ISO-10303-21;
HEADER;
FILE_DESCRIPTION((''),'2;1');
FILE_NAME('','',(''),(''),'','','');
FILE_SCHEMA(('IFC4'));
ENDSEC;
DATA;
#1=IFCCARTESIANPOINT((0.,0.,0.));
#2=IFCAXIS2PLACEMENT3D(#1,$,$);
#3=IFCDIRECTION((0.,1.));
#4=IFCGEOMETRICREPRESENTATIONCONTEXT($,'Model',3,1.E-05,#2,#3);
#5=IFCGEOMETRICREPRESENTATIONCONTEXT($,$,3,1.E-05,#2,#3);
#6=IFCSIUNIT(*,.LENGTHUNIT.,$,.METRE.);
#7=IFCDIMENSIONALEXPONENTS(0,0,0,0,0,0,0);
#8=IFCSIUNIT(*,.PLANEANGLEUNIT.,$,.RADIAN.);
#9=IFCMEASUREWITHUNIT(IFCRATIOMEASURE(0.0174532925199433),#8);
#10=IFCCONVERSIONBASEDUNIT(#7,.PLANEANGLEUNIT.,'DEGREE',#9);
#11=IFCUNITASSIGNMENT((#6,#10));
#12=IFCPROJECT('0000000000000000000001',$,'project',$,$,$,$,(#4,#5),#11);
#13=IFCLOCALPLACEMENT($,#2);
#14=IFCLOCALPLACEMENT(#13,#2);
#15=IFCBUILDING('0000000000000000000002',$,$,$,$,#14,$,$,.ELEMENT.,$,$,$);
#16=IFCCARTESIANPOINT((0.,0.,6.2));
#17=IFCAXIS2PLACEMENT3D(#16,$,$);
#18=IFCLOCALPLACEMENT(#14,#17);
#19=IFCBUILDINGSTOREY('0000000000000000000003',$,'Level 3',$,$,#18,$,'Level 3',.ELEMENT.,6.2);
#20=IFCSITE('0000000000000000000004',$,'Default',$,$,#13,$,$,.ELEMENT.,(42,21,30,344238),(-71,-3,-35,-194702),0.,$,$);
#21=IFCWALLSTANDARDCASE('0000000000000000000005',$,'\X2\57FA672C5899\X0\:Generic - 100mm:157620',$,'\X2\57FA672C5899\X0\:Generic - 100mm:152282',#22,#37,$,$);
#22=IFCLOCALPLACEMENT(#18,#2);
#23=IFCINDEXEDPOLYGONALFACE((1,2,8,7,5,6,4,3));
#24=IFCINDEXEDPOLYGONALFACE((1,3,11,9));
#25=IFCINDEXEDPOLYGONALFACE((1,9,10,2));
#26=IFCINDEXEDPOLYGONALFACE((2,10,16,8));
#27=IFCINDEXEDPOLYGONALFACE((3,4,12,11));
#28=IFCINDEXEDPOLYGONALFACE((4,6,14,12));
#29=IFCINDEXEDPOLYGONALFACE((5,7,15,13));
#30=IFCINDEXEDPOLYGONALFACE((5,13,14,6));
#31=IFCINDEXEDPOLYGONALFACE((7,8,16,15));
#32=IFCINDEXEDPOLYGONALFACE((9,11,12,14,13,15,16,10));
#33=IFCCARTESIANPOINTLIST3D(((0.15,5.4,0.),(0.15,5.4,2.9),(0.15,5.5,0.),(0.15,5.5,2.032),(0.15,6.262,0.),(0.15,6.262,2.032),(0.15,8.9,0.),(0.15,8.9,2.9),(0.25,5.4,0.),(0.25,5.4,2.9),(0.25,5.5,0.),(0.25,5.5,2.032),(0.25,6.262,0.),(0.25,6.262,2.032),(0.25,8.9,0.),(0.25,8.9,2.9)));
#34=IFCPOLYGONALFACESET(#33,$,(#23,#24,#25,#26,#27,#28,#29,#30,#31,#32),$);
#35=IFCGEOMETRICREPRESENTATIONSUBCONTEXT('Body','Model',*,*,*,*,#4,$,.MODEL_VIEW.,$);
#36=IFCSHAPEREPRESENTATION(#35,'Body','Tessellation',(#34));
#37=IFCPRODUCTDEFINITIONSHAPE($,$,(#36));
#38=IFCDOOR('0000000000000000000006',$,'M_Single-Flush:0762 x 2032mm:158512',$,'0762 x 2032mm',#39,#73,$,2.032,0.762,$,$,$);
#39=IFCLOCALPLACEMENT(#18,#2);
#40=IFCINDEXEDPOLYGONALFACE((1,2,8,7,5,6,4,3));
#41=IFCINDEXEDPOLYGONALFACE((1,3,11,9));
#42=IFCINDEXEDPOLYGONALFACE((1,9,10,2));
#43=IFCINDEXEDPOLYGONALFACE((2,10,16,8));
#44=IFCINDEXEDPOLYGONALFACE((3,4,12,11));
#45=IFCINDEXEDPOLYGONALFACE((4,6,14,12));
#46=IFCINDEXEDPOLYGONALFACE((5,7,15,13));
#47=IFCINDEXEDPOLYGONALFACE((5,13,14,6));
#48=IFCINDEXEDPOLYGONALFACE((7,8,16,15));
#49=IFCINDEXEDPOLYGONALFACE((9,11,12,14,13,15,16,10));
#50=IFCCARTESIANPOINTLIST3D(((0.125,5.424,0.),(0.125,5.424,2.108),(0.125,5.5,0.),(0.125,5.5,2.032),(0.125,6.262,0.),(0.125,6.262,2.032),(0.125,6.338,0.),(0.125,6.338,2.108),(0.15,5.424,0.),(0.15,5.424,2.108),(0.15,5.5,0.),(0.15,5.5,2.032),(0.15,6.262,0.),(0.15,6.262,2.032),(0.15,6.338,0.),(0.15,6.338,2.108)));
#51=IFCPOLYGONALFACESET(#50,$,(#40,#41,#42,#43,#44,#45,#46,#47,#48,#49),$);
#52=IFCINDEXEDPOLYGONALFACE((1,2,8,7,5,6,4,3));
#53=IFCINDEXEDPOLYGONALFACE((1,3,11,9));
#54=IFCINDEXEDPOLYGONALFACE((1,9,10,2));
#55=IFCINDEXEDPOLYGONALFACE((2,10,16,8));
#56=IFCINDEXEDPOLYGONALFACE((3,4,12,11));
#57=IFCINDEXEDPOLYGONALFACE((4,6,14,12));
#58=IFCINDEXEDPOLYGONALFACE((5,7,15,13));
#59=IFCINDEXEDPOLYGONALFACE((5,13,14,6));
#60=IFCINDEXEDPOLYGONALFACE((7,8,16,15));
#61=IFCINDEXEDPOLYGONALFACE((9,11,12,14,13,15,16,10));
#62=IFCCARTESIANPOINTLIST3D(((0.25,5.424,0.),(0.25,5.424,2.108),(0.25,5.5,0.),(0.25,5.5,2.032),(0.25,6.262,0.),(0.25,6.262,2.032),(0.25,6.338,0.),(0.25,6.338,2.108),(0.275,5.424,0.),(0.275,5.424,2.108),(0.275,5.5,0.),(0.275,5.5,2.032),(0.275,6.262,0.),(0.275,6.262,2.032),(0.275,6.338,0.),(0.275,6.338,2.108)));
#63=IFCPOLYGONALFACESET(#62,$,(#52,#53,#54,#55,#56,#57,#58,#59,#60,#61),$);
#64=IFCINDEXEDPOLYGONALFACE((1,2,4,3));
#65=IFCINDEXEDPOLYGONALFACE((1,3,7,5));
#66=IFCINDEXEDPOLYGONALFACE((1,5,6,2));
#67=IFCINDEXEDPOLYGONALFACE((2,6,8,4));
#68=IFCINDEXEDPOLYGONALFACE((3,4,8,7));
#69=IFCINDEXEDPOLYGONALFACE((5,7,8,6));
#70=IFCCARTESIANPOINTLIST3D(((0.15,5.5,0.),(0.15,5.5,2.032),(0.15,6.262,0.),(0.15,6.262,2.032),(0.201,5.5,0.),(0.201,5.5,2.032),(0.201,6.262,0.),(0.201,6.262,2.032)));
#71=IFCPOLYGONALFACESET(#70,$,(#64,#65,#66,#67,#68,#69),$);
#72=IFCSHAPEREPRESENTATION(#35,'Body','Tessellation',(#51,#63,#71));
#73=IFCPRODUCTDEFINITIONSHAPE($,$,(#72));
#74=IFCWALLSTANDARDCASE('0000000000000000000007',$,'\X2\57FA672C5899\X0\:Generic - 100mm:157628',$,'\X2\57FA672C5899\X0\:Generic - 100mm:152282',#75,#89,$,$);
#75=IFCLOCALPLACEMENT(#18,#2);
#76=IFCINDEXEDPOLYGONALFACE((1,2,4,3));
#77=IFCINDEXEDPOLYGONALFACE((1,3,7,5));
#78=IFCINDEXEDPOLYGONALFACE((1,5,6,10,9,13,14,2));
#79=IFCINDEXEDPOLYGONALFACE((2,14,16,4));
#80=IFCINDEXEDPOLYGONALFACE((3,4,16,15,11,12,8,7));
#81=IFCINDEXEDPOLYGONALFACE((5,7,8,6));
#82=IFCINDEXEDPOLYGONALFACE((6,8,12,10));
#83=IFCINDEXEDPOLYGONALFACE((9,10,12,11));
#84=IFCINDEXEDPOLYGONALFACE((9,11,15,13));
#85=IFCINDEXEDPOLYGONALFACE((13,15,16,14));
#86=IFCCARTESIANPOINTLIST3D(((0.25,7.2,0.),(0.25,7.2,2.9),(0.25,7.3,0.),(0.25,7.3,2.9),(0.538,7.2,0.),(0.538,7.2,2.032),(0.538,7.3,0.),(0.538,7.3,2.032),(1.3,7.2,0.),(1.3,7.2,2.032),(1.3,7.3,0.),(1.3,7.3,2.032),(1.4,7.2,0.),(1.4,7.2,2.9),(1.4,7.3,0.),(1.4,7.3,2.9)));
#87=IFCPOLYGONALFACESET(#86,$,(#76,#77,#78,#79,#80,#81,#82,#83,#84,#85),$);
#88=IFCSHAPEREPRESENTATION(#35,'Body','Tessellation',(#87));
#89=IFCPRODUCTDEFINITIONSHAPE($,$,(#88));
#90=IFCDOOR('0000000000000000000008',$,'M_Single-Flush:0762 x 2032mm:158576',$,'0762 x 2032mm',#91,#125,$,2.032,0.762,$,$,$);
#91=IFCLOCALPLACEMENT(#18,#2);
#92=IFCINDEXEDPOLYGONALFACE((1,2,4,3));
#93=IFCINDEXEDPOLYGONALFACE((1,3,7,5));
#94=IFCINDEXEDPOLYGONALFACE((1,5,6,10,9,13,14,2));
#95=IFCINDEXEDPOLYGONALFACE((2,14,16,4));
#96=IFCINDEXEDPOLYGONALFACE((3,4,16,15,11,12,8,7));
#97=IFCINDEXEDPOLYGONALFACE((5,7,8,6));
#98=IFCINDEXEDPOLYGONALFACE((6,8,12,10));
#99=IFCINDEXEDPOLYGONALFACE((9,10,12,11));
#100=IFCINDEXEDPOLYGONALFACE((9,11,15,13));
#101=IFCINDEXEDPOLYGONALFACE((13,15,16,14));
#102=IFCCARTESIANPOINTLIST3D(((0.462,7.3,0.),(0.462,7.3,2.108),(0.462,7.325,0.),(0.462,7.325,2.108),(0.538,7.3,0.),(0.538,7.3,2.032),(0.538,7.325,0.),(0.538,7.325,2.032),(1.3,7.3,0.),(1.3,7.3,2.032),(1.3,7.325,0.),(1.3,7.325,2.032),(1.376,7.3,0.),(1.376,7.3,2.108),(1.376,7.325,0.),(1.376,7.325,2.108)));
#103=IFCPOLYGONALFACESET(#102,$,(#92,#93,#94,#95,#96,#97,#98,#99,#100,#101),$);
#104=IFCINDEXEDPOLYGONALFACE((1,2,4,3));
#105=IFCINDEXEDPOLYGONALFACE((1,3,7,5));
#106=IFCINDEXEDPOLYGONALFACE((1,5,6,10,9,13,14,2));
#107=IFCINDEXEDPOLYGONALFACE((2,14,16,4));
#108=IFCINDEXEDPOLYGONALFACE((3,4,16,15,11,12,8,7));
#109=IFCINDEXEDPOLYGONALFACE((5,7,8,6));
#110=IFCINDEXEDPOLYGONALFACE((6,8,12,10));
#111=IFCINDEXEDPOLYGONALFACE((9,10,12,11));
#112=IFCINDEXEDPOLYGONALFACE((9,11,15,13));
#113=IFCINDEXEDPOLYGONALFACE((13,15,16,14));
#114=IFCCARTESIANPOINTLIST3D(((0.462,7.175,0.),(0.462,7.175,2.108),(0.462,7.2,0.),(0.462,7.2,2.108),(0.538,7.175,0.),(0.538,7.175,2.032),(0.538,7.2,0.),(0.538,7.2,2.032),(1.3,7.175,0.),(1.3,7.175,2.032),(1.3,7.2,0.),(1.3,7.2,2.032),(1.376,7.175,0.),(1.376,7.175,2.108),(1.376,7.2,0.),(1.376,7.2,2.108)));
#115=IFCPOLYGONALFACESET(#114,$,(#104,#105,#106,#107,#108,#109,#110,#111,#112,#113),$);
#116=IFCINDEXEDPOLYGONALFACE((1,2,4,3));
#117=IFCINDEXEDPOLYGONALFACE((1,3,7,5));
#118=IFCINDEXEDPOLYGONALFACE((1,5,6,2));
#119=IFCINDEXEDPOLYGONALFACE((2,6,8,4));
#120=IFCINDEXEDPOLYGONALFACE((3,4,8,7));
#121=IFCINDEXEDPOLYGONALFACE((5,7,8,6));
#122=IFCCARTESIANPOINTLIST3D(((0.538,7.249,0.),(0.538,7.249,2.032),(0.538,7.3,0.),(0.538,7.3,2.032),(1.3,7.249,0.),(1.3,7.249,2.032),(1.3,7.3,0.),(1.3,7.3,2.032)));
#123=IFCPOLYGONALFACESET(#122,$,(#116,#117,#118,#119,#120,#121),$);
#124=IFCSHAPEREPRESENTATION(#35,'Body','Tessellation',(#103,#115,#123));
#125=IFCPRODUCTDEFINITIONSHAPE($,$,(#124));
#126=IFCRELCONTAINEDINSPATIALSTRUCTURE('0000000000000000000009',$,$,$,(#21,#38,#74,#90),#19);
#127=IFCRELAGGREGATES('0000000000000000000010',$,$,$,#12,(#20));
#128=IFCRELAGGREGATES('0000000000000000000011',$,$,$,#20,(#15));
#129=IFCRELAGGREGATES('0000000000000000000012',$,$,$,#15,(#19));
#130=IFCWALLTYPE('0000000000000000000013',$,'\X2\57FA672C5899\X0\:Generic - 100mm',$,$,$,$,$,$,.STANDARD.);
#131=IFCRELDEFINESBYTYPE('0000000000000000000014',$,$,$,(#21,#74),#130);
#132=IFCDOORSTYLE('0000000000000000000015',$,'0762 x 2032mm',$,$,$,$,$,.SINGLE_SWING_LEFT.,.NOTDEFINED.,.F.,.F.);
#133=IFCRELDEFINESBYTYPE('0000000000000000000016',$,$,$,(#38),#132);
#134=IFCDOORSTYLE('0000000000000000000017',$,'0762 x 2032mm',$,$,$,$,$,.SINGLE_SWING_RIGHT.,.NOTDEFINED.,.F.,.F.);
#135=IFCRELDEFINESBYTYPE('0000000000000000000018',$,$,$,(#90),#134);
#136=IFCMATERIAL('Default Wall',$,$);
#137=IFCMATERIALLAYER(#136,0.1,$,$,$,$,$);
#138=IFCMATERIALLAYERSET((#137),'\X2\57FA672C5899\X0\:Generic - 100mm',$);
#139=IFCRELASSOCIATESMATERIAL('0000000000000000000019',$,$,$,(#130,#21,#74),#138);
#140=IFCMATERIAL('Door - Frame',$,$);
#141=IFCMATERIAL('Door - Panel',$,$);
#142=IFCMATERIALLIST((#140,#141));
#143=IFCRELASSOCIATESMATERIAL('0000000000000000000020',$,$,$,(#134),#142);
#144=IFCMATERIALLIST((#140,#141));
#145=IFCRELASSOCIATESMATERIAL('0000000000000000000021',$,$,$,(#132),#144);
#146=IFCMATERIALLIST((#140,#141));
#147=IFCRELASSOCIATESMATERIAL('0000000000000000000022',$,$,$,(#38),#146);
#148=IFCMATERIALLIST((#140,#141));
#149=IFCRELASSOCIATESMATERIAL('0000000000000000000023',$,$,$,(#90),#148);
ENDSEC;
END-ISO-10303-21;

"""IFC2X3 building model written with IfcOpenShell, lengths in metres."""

from ifc_helpers import new_model, entity, si_unit, converted_unit, direction, frame, frame_2d, origin, origin_2d_with_axis, place, context, subcontext, project, spatial, polyline, rectangle, outline, extrude, clip, bounded_halfspace, source, transform, mapped, material, material_list, layer, layer_set, layer_usage, type_object, type_shapes, element, fill, save


model = new_model("IFC2X3")

# Units and contexts
model_context = context("Model", 3, precision=1e-05, world=origin(), true_north=direction((0.0, 1.0)))
context_of_model = context(None, 3, precision=1e-05, world=origin(), true_north=direction((0.0, 1.0)))
body_context = subcontext(model_context, "Body", "Model", "MODEL_VIEW")
ifc_project = project(units=[si_unit("LENGTHUNIT", "METRE"), converted_unit("PLANEANGLEUNIT", "DEGREE", entity("IfcRatioMeasure", 0.0174532925199433), si_unit("PLANEANGLEUNIT", "RADIAN"), dimensions=[0, 0, 0, 0, 0, 0, 0])], contexts=[model_context, context_of_model])

# Site, building, storey
site_placement = place(None, origin())
site = spatial("IfcSite", under=ifc_project, at=site_placement, Name="Default", CompositionType="ELEMENT", RefLatitude=(42, 21, 30, 344238), RefLongitude=(-71, -3, -35, -194702), RefElevation=0.0)
building_placement = place(site_placement, origin())
building = spatial("IfcBuilding", under=site, at=building_placement, CompositionType="ELEMENT")
storey_placement = place(building_placement, frame((0.0, 0.0, 6.2)))
storey = spatial("IfcBuildingStorey", under=building, at=storey_placement, Name="Level 3", LongName="Level 3", CompositionType="ELEMENT", Elevation=6.2)

# Shared definitions
ifc_material_1 = material(Name="Default Wall")

# Shared definitions
ifc_material_2 = material(Name="Door - Panel")
ifc_material_3 = material(Name="Door - Frame")

# Shared definitions
ifc_layer_1 = layer(ifc_material_1, 0.1)
ifc_layer_set_1 = layer_set([ifc_layer_1], Name="基本墙:Generic - 100mm")
wall_type_1 = type_object("IfcWallType", Name="基本墙:Generic - 100mm", PredefinedType="STANDARD", material=ifc_layer_set_1)

# Shared definitions
ifc_material_list_1 = material_list([ifc_material_3, ifc_material_2])
door_style_1 = type_object("IfcDoorStyle", Name="0762 x 2032mm", ConstructionType="NOTDEFINED", OperationType="SINGLE_SWING_RIGHT", ParameterTakesPrecedence=False, Sizeable=False, material=ifc_material_list_1)
shared_shape_1 = source(origin(), body_context, "Body", "SweptSolid", [
    extrude(outline(polyline([(-0.457, -1.073), (0.457, -1.073), (0.457, 1.035), (0.381, 1.035), (0.381, -0.997), (-0.381, -0.997), (-0.381, 1.035), (-0.457, 1.035), (-0.457, -1.073)])), frame((0.381, 0.1, 1.035), z_axis=(0.0, 1.0, 0.0), x_axis=(1.0, 0.0, 0.0)), (0.0, 0.0, 1.0), 0.025),
    extrude(outline(polyline([(-1.073, -0.457), (1.035, -0.457), (1.035, -0.381), (-0.997, -0.381), (-0.997, 0.381), (1.035, 0.381), (1.035, 0.457), (-1.073, 0.457), (-1.073, -0.457)])), frame((0.381, -0.025, 1.035), z_axis=(0.0, 1.0, 0.0), x_axis=(0.0, 0.0, -1.0)), (0.0, 0.0, 1.0), 0.025),
    extrude(rectangle(XDim=0.051, YDim=0.762, at=origin_2d_with_axis()), frame((0.381, 0.0745, 0.0), z_axis=(0.0, 0.0, 1.0), x_axis=(0.0, 1.0, 0.0)), (0.0, 0.0, 1.0), 2.032),
])
type_shapes(door_style_1, [shared_shape_1])

# Walls, openings, doors
ifc_layer_usage_1 = layer_usage(ifc_layer_set_1, "AXIS2", "NEGATIVE", 0.05)
wall_1_placement = place(storey_placement, frame((0.2, 8.9, 0.0), z_axis=(0.0, 0.0, 1.0), x_axis=(0.0, -1.0, 0.0)))
wall_1 = element("IfcWallStandardCase", 1, at=wall_1_placement, inside=storey, type_object=wall_type_1, material=ifc_layer_usage_1, Name="基本墙:Generic - 100mm:157620", ObjectType="基本墙:Generic - 100mm:152282", context=body_context, shape_type="Clipping", body=[
    clip(extrude(rectangle(XDim=3.5, YDim=0.1, at=frame_2d((1.75, 0.0), x_axis=(-1.0, 0.0))), origin(), (0.0, 0.0, 1.0), 3.2), bounded_halfspace(frame((0.0, -0.05, 2.9), z_axis=(0.0, 0.0, -1.0), x_axis=(1.0, 0.0, 0.0)), True, frame((0.0, -0.05, 2.9), z_axis=(0.0, 0.0, -1.0), x_axis=(1.0, 0.0, 0.0)), polyline([(0.0, 0.0), (0.0, -0.1), (1.6, -0.1), (1.7, -0.1), (3.5, -0.1), (3.5, 0.0), (0.0, 0.0)]))),
])
opening_1_placement = place(wall_1_placement, frame((3.4, 0.05, 0.0)))
opening_1 = element("IfcOpeningElement", 2, at=opening_1_placement, cuts=wall_1, ObjectType="Opening", context=body_context, shape_type="SweptSolid", body=[
    extrude(rectangle(XDim=0.762, YDim=2.032, at=frame_2d((1.016, 0.381), x_axis=(0.0, -1.0))), frame((0.0, 0.0, 0.0), z_axis=(0.0, -1.0, 0.0), x_axis=(0.0, 0.0, 1.0)), (0.0, 0.0, 1.0), 0.1),
])
ifc_material_list_2 = material_list([ifc_material_3, ifc_material_2])
ifc_material_list_3 = material_list([ifc_material_3, ifc_material_2])
door_style_2 = type_object("IfcDoorStyle", Name="0762 x 2032mm", ConstructionType="NOTDEFINED", OperationType="SINGLE_SWING_LEFT", ParameterTakesPrecedence=False, Sizeable=False, material=ifc_material_list_3)
shared_shape_2 = source(origin(), body_context, "Body", "SweptSolid", [
    extrude(outline(polyline([(-0.457, -1.073), (0.457, -1.073), (0.457, 1.035), (0.381, 1.035), (0.381, -0.997), (-0.381, -0.997), (-0.381, 1.035), (-0.457, 1.035), (-0.457, -1.073)])), frame((0.381, 0.125, 1.035), z_axis=(0.0, -1.0, 0.0), x_axis=(-1.0, 0.0, 0.0)), (0.0, 0.0, 1.0), 0.025),
    extrude(outline(polyline([(-1.073, -0.457), (1.035, -0.457), (1.035, -0.381), (-0.997, -0.381), (-0.997, 0.381), (1.035, 0.381), (1.035, 0.457), (-1.073, 0.457), (-1.073, -0.457)])), frame((0.381, 0.0, 1.035), z_axis=(0.0, -1.0, 0.0), x_axis=(0.0, 0.0, -1.0)), (0.0, 0.0, 1.0), 0.025),
    extrude(rectangle(XDim=0.762, YDim=0.051, at=origin_2d_with_axis()), frame((0.381, 0.0745, 0.0)), (0.0, 0.0, 1.0), 2.032),
])
type_shapes(door_style_2, [shared_shape_2])
door_1_placement = place(opening_1_placement, frame((0.0, 0.0, 0.0), z_axis=(0.0, 0.0, 1.0), x_axis=(-1.0, 0.0, 0.0)))
door_1 = element("IfcDoor", 3, at=door_1_placement, inside=storey, type_object=door_style_2, material=ifc_material_list_2, Name="M_Single-Flush:0762 x 2032mm:158512", ObjectType="0762 x 2032mm", OverallHeight=2.032, OverallWidth=0.762, context=body_context, shape_type="MappedRepresentation", body=[
    mapped(shared_shape_2, transform((0.0, 0.0, 0.0), scale=1.0)),
])
fill(opening_1, door_1)
ifc_layer_usage_2 = layer_usage(ifc_layer_set_1, "AXIS2", "NEGATIVE", 0.05)
wall_2_placement = place(storey_placement, frame((1.4, 7.25, 0.0), z_axis=(0.0, 0.0, 1.0), x_axis=(-1.0, 0.0, 0.0)))
wall_2 = element("IfcWallStandardCase", 4, at=wall_2_placement, inside=storey, type_object=wall_type_1, material=ifc_layer_usage_2, Name="基本墙:Generic - 100mm:157628", ObjectType="基本墙:Generic - 100mm:152282", context=body_context, shape_type="Clipping", body=[
    clip(extrude(rectangle(XDim=1.15, YDim=0.1, at=frame_2d((0.575, 0.0), x_axis=(-1.0, 0.0))), origin(), (0.0, 0.0, 1.0), 3.2), bounded_halfspace(frame((0.0, -0.05, 2.9), z_axis=(0.0, 0.0, -1.0), x_axis=(0.0, 1.0, 0.0)), True, frame((0.0, -0.05, 2.9), z_axis=(0.0, 0.0, -1.0), x_axis=(0.0, 1.0, 0.0)), polyline([(0.0, 0.0), (0.1, 0.0), (0.1, 1.15), (0.0, 1.15), (0.0, 0.0)]))),
])
opening_2_placement = place(wall_2_placement, frame((0.862, 0.05, 0.0)))
opening_2 = element("IfcOpeningElement", 5, at=opening_2_placement, cuts=wall_2, ObjectType="Opening", context=body_context, shape_type="SweptSolid", body=[
    extrude(rectangle(XDim=0.762, YDim=2.032, at=frame_2d((1.016, 0.381), x_axis=(0.0, 1.0))), frame((0.0, 0.0, 0.0), z_axis=(0.0, -1.0, 0.0), x_axis=(0.0, 0.0, 1.0)), (0.0, 0.0, 1.0), 0.1),
])
ifc_material_list_4 = material_list([ifc_material_3, ifc_material_2])
door_2_placement = place(opening_2_placement, frame((0.0, 0.0, 0.0), z_axis=(0.0, 0.0, 1.0), x_axis=(-1.0, 0.0, 0.0)))
door_2 = element("IfcDoor", 6, at=door_2_placement, inside=storey, type_object=door_style_1, material=ifc_material_list_4, Name="M_Single-Flush:0762 x 2032mm:158576", ObjectType="0762 x 2032mm", OverallHeight=2.032, OverallWidth=0.762, context=body_context, shape_type="MappedRepresentation", body=[
    mapped(shared_shape_1, transform((0.0, 0.0, 0.0), scale=1.0)),
])
fill(opening_2, door_2)

save(model, "model.ifc")
